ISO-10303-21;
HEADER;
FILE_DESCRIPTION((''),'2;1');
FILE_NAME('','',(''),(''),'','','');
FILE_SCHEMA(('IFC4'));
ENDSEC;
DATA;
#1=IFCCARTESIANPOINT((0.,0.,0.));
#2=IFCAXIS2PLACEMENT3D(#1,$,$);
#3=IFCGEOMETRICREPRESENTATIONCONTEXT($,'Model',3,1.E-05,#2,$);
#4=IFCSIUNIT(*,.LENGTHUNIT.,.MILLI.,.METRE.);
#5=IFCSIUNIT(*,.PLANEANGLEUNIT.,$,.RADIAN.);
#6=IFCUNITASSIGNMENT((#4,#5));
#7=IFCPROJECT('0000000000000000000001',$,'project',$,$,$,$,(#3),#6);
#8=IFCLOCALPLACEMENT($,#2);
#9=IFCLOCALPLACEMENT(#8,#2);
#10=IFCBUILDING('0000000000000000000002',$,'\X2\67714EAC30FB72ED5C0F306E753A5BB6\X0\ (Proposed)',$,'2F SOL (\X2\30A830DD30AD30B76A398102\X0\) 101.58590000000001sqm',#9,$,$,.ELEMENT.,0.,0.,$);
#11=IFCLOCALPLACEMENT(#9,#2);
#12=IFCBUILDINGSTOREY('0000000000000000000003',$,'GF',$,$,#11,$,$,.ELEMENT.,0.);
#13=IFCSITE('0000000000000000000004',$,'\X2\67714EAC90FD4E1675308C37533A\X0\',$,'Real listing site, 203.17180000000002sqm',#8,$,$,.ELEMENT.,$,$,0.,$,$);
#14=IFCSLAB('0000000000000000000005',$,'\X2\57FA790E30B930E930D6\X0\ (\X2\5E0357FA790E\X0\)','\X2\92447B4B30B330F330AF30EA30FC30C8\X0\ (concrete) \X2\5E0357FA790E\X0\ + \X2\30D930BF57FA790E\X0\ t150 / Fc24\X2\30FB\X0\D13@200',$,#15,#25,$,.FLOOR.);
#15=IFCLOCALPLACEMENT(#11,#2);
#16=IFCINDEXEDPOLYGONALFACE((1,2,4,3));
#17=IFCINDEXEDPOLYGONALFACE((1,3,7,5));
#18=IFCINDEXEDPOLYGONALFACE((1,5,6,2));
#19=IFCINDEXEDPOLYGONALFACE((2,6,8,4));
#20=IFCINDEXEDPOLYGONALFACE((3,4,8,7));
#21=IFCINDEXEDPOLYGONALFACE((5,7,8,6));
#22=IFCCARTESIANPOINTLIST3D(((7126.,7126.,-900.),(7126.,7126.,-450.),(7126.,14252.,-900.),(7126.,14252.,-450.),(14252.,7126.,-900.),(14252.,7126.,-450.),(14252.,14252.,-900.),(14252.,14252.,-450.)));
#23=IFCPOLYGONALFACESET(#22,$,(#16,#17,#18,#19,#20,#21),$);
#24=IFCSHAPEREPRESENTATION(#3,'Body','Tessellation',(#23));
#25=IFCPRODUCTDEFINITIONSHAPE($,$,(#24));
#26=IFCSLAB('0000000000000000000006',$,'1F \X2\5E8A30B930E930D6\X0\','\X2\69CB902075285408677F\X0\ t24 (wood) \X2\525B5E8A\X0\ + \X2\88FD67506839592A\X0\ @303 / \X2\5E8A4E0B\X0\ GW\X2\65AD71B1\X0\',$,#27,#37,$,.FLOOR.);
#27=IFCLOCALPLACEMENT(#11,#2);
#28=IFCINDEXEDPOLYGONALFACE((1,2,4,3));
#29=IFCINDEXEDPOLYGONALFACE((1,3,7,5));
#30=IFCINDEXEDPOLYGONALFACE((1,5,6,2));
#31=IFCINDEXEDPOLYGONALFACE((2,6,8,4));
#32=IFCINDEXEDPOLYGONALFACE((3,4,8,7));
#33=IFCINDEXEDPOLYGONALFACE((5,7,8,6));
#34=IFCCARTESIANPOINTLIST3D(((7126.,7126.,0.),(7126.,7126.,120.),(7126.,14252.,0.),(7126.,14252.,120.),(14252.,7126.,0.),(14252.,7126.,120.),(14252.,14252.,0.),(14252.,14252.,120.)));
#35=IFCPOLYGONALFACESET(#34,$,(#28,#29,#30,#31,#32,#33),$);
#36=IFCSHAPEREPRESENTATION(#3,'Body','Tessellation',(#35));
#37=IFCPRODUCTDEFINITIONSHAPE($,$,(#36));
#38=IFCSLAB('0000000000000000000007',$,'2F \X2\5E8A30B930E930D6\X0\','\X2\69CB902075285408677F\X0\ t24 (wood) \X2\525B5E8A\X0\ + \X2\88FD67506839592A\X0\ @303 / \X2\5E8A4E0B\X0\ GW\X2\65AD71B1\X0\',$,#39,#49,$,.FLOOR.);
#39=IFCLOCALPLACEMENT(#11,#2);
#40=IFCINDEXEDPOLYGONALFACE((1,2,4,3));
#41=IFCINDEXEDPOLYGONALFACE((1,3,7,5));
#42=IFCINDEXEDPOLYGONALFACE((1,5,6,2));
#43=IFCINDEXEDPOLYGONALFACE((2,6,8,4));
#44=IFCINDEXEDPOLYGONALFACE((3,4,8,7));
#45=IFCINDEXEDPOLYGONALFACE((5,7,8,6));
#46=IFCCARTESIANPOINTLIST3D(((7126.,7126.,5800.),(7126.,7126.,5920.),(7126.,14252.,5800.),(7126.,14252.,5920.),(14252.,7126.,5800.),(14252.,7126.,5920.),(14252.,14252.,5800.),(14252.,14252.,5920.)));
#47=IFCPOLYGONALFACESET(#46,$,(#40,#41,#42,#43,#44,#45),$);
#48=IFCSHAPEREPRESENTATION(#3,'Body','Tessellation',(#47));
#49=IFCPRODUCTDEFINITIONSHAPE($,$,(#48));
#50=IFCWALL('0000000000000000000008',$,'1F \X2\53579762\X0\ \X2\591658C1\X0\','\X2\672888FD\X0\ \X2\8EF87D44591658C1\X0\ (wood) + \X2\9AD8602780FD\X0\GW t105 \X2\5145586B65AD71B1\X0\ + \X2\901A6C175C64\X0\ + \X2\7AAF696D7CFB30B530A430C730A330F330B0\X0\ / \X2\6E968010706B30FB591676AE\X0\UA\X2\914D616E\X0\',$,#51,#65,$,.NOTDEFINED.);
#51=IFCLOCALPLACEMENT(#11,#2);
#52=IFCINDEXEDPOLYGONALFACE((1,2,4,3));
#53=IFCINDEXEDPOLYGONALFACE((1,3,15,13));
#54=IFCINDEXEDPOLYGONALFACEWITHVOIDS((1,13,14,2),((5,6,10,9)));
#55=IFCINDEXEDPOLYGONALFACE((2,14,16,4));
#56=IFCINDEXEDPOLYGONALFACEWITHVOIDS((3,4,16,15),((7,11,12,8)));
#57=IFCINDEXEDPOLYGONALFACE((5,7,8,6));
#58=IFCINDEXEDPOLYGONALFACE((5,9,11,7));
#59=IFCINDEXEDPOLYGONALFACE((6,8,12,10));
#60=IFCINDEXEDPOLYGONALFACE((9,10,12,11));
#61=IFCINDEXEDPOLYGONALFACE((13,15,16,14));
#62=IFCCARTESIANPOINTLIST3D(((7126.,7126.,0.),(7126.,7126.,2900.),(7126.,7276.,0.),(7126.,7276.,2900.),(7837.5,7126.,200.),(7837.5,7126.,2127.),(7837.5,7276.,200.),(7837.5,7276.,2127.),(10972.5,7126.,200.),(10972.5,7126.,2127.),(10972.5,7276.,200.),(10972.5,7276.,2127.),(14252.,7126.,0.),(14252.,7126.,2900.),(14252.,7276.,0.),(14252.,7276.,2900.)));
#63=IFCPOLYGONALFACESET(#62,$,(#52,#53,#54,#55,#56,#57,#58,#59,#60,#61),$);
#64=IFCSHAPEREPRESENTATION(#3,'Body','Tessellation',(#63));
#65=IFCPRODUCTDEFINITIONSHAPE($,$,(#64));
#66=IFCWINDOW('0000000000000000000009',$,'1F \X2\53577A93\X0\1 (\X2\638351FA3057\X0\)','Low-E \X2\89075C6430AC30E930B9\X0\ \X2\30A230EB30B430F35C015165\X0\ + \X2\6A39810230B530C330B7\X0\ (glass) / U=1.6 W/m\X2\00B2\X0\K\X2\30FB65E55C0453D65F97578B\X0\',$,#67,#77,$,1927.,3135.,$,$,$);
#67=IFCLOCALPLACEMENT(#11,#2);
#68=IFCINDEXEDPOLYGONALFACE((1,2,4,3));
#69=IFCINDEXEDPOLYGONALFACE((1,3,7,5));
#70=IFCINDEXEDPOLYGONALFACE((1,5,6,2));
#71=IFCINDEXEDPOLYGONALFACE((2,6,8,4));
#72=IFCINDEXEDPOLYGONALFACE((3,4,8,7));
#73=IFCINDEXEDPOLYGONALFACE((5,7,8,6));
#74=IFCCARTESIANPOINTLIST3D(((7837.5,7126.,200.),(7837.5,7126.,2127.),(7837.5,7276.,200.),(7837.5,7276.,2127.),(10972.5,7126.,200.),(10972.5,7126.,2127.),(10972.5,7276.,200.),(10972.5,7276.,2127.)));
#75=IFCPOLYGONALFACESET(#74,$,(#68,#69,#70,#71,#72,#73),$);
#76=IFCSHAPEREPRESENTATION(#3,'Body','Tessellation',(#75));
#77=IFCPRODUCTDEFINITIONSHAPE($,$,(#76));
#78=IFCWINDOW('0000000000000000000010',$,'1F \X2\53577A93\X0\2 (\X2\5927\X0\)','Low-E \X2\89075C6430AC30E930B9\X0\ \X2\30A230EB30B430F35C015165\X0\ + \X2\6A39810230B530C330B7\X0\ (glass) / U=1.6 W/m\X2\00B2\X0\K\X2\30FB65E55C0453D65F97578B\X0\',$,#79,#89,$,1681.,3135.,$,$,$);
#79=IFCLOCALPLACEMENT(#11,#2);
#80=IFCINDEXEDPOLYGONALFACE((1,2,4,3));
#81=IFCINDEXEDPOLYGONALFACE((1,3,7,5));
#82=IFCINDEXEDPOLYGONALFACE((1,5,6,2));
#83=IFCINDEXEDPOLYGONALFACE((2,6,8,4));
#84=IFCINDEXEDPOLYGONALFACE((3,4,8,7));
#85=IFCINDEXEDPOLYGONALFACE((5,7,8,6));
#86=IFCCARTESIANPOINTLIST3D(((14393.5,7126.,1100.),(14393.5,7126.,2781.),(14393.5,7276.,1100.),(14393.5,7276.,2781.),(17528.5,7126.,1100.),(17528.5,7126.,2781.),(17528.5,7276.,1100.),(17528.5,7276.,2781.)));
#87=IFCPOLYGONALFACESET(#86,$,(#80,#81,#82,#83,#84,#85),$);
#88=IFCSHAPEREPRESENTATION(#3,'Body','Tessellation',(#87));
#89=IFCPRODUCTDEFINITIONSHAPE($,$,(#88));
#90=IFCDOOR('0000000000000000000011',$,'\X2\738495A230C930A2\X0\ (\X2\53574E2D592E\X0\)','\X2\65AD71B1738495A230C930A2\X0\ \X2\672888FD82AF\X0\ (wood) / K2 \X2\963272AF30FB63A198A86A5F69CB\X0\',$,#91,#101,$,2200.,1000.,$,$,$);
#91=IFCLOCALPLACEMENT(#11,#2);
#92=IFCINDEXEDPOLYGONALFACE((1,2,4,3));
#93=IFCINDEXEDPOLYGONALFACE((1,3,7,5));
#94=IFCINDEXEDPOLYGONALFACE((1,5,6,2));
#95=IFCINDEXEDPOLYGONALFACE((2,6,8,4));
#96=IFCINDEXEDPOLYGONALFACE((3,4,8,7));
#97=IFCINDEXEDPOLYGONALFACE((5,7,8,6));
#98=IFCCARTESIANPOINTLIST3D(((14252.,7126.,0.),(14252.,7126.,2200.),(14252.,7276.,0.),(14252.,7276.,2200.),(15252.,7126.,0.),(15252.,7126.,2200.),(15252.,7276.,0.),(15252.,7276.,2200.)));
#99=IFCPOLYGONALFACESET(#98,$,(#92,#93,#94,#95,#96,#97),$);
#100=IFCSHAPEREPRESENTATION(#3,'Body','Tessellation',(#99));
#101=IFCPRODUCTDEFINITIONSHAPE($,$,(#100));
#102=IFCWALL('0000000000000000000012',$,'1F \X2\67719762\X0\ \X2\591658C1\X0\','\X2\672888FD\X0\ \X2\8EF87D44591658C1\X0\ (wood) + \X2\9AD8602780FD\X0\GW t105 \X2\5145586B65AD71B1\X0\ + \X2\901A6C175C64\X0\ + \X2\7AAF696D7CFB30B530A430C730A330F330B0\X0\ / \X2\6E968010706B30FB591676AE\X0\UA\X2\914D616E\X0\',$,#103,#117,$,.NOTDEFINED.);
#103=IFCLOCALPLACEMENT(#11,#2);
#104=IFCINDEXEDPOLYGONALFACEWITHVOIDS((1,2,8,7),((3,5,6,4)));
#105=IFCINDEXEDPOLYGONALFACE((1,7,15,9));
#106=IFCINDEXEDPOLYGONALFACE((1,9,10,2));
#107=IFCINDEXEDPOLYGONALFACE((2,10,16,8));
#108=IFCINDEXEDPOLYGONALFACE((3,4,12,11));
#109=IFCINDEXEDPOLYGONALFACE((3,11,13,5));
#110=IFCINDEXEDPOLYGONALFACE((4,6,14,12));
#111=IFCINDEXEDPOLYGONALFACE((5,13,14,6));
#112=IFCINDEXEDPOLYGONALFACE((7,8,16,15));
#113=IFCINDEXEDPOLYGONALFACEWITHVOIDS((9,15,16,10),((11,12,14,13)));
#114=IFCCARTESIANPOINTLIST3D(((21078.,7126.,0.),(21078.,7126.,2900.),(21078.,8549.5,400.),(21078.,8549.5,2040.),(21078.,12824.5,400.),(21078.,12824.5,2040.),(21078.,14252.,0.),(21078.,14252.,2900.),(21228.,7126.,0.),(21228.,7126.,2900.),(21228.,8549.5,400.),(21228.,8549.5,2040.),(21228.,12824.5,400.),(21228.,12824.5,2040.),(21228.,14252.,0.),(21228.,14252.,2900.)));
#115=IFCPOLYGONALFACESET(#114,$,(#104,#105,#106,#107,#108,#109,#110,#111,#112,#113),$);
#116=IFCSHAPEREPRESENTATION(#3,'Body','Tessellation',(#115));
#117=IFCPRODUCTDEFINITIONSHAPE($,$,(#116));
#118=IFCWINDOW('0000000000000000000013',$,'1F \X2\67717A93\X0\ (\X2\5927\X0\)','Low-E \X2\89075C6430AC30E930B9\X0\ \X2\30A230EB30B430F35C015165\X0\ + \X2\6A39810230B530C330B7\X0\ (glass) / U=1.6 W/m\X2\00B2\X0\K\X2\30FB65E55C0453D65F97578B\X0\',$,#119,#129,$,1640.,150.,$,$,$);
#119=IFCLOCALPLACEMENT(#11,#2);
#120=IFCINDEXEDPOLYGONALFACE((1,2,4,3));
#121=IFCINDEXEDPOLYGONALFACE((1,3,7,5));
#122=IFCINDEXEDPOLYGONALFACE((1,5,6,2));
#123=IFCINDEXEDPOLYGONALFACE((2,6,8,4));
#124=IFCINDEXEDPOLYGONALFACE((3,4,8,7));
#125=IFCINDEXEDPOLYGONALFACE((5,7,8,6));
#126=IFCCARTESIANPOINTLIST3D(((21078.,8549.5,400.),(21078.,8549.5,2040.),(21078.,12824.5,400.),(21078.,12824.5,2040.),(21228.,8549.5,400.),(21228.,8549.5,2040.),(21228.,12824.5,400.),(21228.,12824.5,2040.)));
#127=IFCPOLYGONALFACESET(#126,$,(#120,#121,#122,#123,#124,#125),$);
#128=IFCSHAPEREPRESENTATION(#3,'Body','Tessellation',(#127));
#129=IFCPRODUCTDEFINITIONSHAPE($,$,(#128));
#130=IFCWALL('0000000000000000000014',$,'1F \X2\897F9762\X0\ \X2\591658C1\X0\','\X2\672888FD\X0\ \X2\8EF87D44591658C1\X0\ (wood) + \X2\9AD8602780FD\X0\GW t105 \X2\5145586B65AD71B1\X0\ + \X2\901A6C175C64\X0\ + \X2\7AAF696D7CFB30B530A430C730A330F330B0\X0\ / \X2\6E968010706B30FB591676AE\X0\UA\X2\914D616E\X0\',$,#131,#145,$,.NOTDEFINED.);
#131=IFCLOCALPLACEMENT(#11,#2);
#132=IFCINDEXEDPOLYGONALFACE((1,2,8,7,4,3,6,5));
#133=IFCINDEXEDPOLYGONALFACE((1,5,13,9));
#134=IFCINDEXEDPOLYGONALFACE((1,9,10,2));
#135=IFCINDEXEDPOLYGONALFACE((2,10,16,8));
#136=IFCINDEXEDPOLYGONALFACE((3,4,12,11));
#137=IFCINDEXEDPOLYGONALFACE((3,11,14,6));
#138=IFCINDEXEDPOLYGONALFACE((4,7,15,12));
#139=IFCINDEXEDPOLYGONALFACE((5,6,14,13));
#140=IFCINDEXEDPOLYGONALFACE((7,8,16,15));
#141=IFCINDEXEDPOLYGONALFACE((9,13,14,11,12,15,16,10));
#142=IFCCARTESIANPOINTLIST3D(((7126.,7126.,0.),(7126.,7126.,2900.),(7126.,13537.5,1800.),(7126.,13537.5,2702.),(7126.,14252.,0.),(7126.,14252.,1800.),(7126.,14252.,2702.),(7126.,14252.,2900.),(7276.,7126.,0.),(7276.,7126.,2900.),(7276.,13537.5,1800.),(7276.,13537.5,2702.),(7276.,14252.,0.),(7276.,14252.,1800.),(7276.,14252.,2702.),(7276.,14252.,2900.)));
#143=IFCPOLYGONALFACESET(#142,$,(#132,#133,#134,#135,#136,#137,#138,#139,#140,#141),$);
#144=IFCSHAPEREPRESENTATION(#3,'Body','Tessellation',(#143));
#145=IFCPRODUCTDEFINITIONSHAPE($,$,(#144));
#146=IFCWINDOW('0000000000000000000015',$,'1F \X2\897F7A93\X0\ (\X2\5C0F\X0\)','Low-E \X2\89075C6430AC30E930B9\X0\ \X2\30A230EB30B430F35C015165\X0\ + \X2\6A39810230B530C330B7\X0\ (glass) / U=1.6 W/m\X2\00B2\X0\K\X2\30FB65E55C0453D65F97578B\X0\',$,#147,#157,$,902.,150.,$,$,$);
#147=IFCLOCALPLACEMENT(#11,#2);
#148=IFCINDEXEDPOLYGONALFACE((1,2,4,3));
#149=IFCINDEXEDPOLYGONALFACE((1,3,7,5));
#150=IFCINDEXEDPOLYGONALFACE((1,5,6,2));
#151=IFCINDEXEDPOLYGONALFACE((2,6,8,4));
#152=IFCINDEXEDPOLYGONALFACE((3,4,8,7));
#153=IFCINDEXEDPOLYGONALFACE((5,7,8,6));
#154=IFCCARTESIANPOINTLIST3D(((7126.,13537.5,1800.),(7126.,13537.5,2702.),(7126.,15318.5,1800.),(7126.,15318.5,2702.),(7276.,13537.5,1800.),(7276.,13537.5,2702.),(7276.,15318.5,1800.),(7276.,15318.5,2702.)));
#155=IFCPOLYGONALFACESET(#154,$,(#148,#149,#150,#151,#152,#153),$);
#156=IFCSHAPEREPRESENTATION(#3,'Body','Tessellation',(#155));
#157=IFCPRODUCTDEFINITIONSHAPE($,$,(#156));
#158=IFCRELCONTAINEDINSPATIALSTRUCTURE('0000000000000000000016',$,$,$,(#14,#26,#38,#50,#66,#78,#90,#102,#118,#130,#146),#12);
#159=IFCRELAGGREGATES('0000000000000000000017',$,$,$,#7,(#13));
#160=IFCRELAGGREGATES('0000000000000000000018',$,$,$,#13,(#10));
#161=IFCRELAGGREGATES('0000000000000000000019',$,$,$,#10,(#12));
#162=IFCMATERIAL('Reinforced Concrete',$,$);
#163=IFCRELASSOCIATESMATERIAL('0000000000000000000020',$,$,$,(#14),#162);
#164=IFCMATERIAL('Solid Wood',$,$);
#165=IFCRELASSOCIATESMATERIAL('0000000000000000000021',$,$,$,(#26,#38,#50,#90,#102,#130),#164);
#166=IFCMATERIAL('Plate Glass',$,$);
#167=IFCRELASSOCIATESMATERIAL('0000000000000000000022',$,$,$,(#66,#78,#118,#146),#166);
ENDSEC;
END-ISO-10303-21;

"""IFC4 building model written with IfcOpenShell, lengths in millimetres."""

from ifc_helpers import new_model, si_unit, frame, frame_2d, origin, place, context, project, spatial, rectangle, extrude, material, element, fill, save


model = new_model("IFC4")

# Units and contexts
model_context = context("Model", 3, precision=1e-05, world=origin())
ifc_project = project(units=[si_unit("LENGTHUNIT", "METRE", prefix="MILLI"), si_unit("PLANEANGLEUNIT", "RADIAN")], contexts=[model_context])

# Site, building, storey
site_placement = place(None, origin())
site = spatial("IfcSite", under=ifc_project, at=site_placement, Name="東京都世田谷区", ObjectType="Real listing site, 203.17180000000002sqm", CompositionType="ELEMENT", RefElevation=0.0)
building_placement = place(site_placement, origin())
building = spatial("IfcBuilding", under=site, at=building_placement, Name="東京・狭小の町家 (Proposed)", ObjectType="2F SOL (エポキシ樹脂) 101.58590000000001sqm", CompositionType="ELEMENT", ElevationOfRefHeight=0.0, ElevationOfTerrain=0.0)
storey_placement = place(building_placement, origin())
storey = spatial("IfcBuildingStorey", under=building, at=storey_placement, Name="GF", CompositionType="ELEMENT", Elevation=0.0)

# Slabs
ifc_material_1 = material(Name="Reinforced Concrete")
slab_1_placement = place(storey_placement, frame((3563.0, 3563.0, -450.0)))
element("IfcSlab", 1, at=slab_1_placement, inside=storey, material=ifc_material_1, Name="基礎スラブ (布基礎)", Description="鉄筋コンクリート (concrete) 布基礎 + ベタ基礎 t150 / Fc24・D13@200", PredefinedType="FLOOR", context=model_context, shape_type="SweptSolid", body=[
    extrude(rectangle(XDim=7126.0, YDim=7126.0, at=frame_2d((3563.0, 3563.0))), frame((3563.0, 3563.0, -450.0)), (0.0, 0.0, 1.0), 450.0),
])
ifc_material_2 = material(Name="Solid Wood")
slab_2_placement = place(storey_placement, frame((3563.0, 3563.0, 0.0)))
element("IfcSlab", 2, at=slab_2_placement, inside=storey, material=ifc_material_2, Name="1F 床スラブ", Description="構造用合板 t24 (wood) 剛床 + 製材根太 @303 / 床下 GW断熱", PredefinedType="FLOOR", context=model_context, shape_type="SweptSolid", body=[
    extrude(rectangle(XDim=7126.0, YDim=7126.0, at=frame_2d((3563.0, 3563.0))), frame((3563.0, 3563.0, 0.0)), (0.0, 0.0, 1.0), 120.0),
])
slab_3_placement = place(storey_placement, frame((3563.0, 3563.0, 2900.0)))
element("IfcSlab", 3, at=slab_3_placement, inside=storey, material=ifc_material_2, Name="2F 床スラブ", Description="構造用合板 t24 (wood) 剛床 + 製材根太 @303 / 床下 GW断熱", PredefinedType="FLOOR", context=model_context, shape_type="SweptSolid", body=[
    extrude(rectangle(XDim=7126.0, YDim=7126.0, at=frame_2d((3563.0, 3563.0))), frame((3563.0, 3563.0, 2900.0)), (0.0, 0.0, 1.0), 120.0),
])

# Wall, openings, windows, door
wall_1_placement = place(storey_placement, frame((3563.0, 3563.0, 0.0)))
wall_1 = element("IfcWall", 4, at=wall_1_placement, inside=storey, material=ifc_material_2, Name="1F 南面 外壁", Description="木製 軸組外壁 (wood) + 高性能GW t105 充填断熱 + 通気層 + 窯業系サイディング / 準耐火・外皮UA配慮", PredefinedType="NOTDEFINED", context=model_context, shape_type="SweptSolid", body=[
    extrude(rectangle(XDim=7126.0, YDim=150.0, at=frame_2d((3563.0, 75.0))), frame((3563.0, 3563.0, 0.0)), (0.0, 0.0, 1.0), 2900.0),
])
opening_1_placement = place(storey_placement, frame((3919.0, 3563.0, 100.0)))
opening_1 = element("IfcOpeningElement", 5, at=opening_1_placement, cuts=wall_1, PredefinedType="NOTDEFINED", context=model_context, shape_type="SweptSolid", body=[
    extrude(rectangle(XDim=3135.0, YDim=150.0, at=frame_2d((1567.0, 75.0))), frame((3919.0, 3563.0, 100.0)), (0.0, 0.0, 1.0), 1927.0),
])
opening_2_placement = place(storey_placement, frame((7197.0, 3563.0, 550.0)))
opening_2 = element("IfcOpeningElement", 6, at=opening_2_placement, cuts=wall_1, PredefinedType="NOTDEFINED", context=model_context, shape_type="SweptSolid", body=[
    extrude(rectangle(XDim=3135.0, YDim=150.0, at=frame_2d((1567.0, 75.0))), frame((7197.0, 3563.0, 550.0)), (0.0, 0.0, 1.0), 1681.0),
])
opening_3_placement = place(storey_placement, frame((7126.0, 3563.0, 0.0)))
opening_3 = element("IfcOpeningElement", 7, at=opening_3_placement, cuts=wall_1, PredefinedType="NOTDEFINED", context=model_context, shape_type="SweptSolid", body=[
    extrude(rectangle(XDim=1000.0, YDim=150.0, at=frame_2d((500.0, 75.0))), frame((7126.0, 3563.0, 0.0)), (0.0, 0.0, 1.0), 2200.0),
])
ifc_material_3 = material(Name="Plate Glass")
window_1_placement = place(storey_placement, frame((3919.0, 3563.0, 100.0)))
window_1 = element("IfcWindow", 8, at=window_1_placement, inside=storey, material=ifc_material_3, Name="1F 南窓1 (掃出し)", Description="Low-E 複層ガラス アルゴン封入 + 樹脂サッシ (glass) / U=1.6 W/m²K・日射取得型", OverallHeight=1927.0, OverallWidth=3135.0, context=model_context, shape_type="SweptSolid", body=[
    extrude(rectangle(XDim=3135.0, YDim=150.0, at=frame_2d((1567.0, 75.0))), frame((3919.0, 3563.0, 100.0)), (0.0, 0.0, 1.0), 1927.0),
])
fill(opening_1, window_1)
window_2_placement = place(storey_placement, frame((7197.0, 3563.0, 550.0)))
window_2 = element("IfcWindow", 9, at=window_2_placement, inside=storey, material=ifc_material_3, Name="1F 南窓2 (大)", Description="Low-E 複層ガラス アルゴン封入 + 樹脂サッシ (glass) / U=1.6 W/m²K・日射取得型", OverallHeight=1681.0, OverallWidth=3135.0, context=model_context, shape_type="SweptSolid", body=[
    extrude(rectangle(XDim=3135.0, YDim=150.0, at=frame_2d((1567.0, 75.0))), frame((7197.0, 3563.0, 550.0)), (0.0, 0.0, 1.0), 1681.0),
])
fill(opening_2, window_2)
door_placement = place(storey_placement, frame((7126.0, 3563.0, 0.0)))
door = element("IfcDoor", 10, at=door_placement, inside=storey, material=ifc_material_2, Name="玄関ドア (南中央)", Description="断熱玄関ドア 木製芯 (wood) / K2 防犯・採風機構", OverallHeight=2200.0, OverallWidth=1000.0, context=model_context, shape_type="SweptSolid", body=[
    extrude(rectangle(XDim=1000.0, YDim=150.0, at=frame_2d((500.0, 75.0))), frame((7126.0, 3563.0, 0.0)), (0.0, 0.0, 1.0), 2200.0),
])
fill(opening_3, door)

# Walls, openings, windows
wall_2_placement = place(storey_placement, frame((10539.0, 3563.0, 0.0)))
wall_2 = element("IfcWall", 11, at=wall_2_placement, inside=storey, material=ifc_material_2, Name="1F 東面 外壁", Description="木製 軸組外壁 (wood) + 高性能GW t105 充填断熱 + 通気層 + 窯業系サイディング / 準耐火・外皮UA配慮", PredefinedType="NOTDEFINED", context=model_context, shape_type="SweptSolid", body=[
    extrude(rectangle(XDim=150.0, YDim=7126.0, at=frame_2d((75.0, 3563.0))), frame((10539.0, 3563.0, 0.0)), (0.0, 0.0, 1.0), 2900.0),
])
opening_4_placement = place(storey_placement, frame((10539.0, 4275.0, 200.0)))
opening_4 = element("IfcOpeningElement", 12, at=opening_4_placement, cuts=wall_2, PredefinedType="NOTDEFINED", context=model_context, shape_type="SweptSolid", body=[
    extrude(rectangle(XDim=150.0, YDim=4275.0, at=frame_2d((75.0, 2137.0))), frame((10539.0, 4275.0, 200.0)), (0.0, 0.0, 1.0), 1640.0),
])
window_3_placement = place(storey_placement, frame((10539.0, 4275.0, 200.0)))
window_3 = element("IfcWindow", 13, at=window_3_placement, inside=storey, material=ifc_material_3, Name="1F 東窓 (大)", Description="Low-E 複層ガラス アルゴン封入 + 樹脂サッシ (glass) / U=1.6 W/m²K・日射取得型", OverallHeight=1640.0, OverallWidth=150.0, context=model_context, shape_type="SweptSolid", body=[
    extrude(rectangle(XDim=150.0, YDim=4275.0, at=frame_2d((75.0, 2137.0))), frame((10539.0, 4275.0, 200.0)), (0.0, 0.0, 1.0), 1640.0),
])
fill(opening_4, window_3)
wall_3_placement = place(storey_placement, frame((3563.0, 3563.0, 0.0)))
wall_3 = element("IfcWall", 14, at=wall_3_placement, inside=storey, material=ifc_material_2, Name="1F 西面 外壁", Description="木製 軸組外壁 (wood) + 高性能GW t105 充填断熱 + 通気層 + 窯業系サイディング / 準耐火・外皮UA配慮", PredefinedType="NOTDEFINED", context=model_context, shape_type="SweptSolid", body=[
    extrude(rectangle(XDim=150.0, YDim=7126.0, at=frame_2d((75.0, 3563.0))), frame((3563.0, 3563.0, 0.0)), (0.0, 0.0, 1.0), 2900.0),
])
opening_5_placement = place(storey_placement, frame((3563.0, 6769.0, 900.0)))
opening_5 = element("IfcOpeningElement", 15, at=opening_5_placement, cuts=wall_3, PredefinedType="NOTDEFINED", context=model_context, shape_type="SweptSolid", body=[
    extrude(rectangle(XDim=150.0, YDim=1781.0, at=frame_2d((75.0, 890.0))), frame((3563.0, 6769.0, 900.0)), (0.0, 0.0, 1.0), 902.0),
])
window_4_placement = place(storey_placement, frame((3563.0, 6769.0, 900.0)))
window_4 = element("IfcWindow", 16, at=window_4_placement, inside=storey, material=ifc_material_3, Name="1F 西窓 (小)", Description="Low-E 複層ガラス アルゴン封入 + 樹脂サッシ (glass) / U=1.6 W/m²K・日射取得型", OverallHeight=902.0, OverallWidth=150.0, context=model_context, shape_type="SweptSolid", body=[
    extrude(rectangle(XDim=150.0, YDim=1781.0, at=frame_2d((75.0, 890.0))), frame((3563.0, 6769.0, 900.0)), (0.0, 0.0, 1.0), 902.0),
])
fill(opening_5, window_4)

save(model, "model.ifc")
